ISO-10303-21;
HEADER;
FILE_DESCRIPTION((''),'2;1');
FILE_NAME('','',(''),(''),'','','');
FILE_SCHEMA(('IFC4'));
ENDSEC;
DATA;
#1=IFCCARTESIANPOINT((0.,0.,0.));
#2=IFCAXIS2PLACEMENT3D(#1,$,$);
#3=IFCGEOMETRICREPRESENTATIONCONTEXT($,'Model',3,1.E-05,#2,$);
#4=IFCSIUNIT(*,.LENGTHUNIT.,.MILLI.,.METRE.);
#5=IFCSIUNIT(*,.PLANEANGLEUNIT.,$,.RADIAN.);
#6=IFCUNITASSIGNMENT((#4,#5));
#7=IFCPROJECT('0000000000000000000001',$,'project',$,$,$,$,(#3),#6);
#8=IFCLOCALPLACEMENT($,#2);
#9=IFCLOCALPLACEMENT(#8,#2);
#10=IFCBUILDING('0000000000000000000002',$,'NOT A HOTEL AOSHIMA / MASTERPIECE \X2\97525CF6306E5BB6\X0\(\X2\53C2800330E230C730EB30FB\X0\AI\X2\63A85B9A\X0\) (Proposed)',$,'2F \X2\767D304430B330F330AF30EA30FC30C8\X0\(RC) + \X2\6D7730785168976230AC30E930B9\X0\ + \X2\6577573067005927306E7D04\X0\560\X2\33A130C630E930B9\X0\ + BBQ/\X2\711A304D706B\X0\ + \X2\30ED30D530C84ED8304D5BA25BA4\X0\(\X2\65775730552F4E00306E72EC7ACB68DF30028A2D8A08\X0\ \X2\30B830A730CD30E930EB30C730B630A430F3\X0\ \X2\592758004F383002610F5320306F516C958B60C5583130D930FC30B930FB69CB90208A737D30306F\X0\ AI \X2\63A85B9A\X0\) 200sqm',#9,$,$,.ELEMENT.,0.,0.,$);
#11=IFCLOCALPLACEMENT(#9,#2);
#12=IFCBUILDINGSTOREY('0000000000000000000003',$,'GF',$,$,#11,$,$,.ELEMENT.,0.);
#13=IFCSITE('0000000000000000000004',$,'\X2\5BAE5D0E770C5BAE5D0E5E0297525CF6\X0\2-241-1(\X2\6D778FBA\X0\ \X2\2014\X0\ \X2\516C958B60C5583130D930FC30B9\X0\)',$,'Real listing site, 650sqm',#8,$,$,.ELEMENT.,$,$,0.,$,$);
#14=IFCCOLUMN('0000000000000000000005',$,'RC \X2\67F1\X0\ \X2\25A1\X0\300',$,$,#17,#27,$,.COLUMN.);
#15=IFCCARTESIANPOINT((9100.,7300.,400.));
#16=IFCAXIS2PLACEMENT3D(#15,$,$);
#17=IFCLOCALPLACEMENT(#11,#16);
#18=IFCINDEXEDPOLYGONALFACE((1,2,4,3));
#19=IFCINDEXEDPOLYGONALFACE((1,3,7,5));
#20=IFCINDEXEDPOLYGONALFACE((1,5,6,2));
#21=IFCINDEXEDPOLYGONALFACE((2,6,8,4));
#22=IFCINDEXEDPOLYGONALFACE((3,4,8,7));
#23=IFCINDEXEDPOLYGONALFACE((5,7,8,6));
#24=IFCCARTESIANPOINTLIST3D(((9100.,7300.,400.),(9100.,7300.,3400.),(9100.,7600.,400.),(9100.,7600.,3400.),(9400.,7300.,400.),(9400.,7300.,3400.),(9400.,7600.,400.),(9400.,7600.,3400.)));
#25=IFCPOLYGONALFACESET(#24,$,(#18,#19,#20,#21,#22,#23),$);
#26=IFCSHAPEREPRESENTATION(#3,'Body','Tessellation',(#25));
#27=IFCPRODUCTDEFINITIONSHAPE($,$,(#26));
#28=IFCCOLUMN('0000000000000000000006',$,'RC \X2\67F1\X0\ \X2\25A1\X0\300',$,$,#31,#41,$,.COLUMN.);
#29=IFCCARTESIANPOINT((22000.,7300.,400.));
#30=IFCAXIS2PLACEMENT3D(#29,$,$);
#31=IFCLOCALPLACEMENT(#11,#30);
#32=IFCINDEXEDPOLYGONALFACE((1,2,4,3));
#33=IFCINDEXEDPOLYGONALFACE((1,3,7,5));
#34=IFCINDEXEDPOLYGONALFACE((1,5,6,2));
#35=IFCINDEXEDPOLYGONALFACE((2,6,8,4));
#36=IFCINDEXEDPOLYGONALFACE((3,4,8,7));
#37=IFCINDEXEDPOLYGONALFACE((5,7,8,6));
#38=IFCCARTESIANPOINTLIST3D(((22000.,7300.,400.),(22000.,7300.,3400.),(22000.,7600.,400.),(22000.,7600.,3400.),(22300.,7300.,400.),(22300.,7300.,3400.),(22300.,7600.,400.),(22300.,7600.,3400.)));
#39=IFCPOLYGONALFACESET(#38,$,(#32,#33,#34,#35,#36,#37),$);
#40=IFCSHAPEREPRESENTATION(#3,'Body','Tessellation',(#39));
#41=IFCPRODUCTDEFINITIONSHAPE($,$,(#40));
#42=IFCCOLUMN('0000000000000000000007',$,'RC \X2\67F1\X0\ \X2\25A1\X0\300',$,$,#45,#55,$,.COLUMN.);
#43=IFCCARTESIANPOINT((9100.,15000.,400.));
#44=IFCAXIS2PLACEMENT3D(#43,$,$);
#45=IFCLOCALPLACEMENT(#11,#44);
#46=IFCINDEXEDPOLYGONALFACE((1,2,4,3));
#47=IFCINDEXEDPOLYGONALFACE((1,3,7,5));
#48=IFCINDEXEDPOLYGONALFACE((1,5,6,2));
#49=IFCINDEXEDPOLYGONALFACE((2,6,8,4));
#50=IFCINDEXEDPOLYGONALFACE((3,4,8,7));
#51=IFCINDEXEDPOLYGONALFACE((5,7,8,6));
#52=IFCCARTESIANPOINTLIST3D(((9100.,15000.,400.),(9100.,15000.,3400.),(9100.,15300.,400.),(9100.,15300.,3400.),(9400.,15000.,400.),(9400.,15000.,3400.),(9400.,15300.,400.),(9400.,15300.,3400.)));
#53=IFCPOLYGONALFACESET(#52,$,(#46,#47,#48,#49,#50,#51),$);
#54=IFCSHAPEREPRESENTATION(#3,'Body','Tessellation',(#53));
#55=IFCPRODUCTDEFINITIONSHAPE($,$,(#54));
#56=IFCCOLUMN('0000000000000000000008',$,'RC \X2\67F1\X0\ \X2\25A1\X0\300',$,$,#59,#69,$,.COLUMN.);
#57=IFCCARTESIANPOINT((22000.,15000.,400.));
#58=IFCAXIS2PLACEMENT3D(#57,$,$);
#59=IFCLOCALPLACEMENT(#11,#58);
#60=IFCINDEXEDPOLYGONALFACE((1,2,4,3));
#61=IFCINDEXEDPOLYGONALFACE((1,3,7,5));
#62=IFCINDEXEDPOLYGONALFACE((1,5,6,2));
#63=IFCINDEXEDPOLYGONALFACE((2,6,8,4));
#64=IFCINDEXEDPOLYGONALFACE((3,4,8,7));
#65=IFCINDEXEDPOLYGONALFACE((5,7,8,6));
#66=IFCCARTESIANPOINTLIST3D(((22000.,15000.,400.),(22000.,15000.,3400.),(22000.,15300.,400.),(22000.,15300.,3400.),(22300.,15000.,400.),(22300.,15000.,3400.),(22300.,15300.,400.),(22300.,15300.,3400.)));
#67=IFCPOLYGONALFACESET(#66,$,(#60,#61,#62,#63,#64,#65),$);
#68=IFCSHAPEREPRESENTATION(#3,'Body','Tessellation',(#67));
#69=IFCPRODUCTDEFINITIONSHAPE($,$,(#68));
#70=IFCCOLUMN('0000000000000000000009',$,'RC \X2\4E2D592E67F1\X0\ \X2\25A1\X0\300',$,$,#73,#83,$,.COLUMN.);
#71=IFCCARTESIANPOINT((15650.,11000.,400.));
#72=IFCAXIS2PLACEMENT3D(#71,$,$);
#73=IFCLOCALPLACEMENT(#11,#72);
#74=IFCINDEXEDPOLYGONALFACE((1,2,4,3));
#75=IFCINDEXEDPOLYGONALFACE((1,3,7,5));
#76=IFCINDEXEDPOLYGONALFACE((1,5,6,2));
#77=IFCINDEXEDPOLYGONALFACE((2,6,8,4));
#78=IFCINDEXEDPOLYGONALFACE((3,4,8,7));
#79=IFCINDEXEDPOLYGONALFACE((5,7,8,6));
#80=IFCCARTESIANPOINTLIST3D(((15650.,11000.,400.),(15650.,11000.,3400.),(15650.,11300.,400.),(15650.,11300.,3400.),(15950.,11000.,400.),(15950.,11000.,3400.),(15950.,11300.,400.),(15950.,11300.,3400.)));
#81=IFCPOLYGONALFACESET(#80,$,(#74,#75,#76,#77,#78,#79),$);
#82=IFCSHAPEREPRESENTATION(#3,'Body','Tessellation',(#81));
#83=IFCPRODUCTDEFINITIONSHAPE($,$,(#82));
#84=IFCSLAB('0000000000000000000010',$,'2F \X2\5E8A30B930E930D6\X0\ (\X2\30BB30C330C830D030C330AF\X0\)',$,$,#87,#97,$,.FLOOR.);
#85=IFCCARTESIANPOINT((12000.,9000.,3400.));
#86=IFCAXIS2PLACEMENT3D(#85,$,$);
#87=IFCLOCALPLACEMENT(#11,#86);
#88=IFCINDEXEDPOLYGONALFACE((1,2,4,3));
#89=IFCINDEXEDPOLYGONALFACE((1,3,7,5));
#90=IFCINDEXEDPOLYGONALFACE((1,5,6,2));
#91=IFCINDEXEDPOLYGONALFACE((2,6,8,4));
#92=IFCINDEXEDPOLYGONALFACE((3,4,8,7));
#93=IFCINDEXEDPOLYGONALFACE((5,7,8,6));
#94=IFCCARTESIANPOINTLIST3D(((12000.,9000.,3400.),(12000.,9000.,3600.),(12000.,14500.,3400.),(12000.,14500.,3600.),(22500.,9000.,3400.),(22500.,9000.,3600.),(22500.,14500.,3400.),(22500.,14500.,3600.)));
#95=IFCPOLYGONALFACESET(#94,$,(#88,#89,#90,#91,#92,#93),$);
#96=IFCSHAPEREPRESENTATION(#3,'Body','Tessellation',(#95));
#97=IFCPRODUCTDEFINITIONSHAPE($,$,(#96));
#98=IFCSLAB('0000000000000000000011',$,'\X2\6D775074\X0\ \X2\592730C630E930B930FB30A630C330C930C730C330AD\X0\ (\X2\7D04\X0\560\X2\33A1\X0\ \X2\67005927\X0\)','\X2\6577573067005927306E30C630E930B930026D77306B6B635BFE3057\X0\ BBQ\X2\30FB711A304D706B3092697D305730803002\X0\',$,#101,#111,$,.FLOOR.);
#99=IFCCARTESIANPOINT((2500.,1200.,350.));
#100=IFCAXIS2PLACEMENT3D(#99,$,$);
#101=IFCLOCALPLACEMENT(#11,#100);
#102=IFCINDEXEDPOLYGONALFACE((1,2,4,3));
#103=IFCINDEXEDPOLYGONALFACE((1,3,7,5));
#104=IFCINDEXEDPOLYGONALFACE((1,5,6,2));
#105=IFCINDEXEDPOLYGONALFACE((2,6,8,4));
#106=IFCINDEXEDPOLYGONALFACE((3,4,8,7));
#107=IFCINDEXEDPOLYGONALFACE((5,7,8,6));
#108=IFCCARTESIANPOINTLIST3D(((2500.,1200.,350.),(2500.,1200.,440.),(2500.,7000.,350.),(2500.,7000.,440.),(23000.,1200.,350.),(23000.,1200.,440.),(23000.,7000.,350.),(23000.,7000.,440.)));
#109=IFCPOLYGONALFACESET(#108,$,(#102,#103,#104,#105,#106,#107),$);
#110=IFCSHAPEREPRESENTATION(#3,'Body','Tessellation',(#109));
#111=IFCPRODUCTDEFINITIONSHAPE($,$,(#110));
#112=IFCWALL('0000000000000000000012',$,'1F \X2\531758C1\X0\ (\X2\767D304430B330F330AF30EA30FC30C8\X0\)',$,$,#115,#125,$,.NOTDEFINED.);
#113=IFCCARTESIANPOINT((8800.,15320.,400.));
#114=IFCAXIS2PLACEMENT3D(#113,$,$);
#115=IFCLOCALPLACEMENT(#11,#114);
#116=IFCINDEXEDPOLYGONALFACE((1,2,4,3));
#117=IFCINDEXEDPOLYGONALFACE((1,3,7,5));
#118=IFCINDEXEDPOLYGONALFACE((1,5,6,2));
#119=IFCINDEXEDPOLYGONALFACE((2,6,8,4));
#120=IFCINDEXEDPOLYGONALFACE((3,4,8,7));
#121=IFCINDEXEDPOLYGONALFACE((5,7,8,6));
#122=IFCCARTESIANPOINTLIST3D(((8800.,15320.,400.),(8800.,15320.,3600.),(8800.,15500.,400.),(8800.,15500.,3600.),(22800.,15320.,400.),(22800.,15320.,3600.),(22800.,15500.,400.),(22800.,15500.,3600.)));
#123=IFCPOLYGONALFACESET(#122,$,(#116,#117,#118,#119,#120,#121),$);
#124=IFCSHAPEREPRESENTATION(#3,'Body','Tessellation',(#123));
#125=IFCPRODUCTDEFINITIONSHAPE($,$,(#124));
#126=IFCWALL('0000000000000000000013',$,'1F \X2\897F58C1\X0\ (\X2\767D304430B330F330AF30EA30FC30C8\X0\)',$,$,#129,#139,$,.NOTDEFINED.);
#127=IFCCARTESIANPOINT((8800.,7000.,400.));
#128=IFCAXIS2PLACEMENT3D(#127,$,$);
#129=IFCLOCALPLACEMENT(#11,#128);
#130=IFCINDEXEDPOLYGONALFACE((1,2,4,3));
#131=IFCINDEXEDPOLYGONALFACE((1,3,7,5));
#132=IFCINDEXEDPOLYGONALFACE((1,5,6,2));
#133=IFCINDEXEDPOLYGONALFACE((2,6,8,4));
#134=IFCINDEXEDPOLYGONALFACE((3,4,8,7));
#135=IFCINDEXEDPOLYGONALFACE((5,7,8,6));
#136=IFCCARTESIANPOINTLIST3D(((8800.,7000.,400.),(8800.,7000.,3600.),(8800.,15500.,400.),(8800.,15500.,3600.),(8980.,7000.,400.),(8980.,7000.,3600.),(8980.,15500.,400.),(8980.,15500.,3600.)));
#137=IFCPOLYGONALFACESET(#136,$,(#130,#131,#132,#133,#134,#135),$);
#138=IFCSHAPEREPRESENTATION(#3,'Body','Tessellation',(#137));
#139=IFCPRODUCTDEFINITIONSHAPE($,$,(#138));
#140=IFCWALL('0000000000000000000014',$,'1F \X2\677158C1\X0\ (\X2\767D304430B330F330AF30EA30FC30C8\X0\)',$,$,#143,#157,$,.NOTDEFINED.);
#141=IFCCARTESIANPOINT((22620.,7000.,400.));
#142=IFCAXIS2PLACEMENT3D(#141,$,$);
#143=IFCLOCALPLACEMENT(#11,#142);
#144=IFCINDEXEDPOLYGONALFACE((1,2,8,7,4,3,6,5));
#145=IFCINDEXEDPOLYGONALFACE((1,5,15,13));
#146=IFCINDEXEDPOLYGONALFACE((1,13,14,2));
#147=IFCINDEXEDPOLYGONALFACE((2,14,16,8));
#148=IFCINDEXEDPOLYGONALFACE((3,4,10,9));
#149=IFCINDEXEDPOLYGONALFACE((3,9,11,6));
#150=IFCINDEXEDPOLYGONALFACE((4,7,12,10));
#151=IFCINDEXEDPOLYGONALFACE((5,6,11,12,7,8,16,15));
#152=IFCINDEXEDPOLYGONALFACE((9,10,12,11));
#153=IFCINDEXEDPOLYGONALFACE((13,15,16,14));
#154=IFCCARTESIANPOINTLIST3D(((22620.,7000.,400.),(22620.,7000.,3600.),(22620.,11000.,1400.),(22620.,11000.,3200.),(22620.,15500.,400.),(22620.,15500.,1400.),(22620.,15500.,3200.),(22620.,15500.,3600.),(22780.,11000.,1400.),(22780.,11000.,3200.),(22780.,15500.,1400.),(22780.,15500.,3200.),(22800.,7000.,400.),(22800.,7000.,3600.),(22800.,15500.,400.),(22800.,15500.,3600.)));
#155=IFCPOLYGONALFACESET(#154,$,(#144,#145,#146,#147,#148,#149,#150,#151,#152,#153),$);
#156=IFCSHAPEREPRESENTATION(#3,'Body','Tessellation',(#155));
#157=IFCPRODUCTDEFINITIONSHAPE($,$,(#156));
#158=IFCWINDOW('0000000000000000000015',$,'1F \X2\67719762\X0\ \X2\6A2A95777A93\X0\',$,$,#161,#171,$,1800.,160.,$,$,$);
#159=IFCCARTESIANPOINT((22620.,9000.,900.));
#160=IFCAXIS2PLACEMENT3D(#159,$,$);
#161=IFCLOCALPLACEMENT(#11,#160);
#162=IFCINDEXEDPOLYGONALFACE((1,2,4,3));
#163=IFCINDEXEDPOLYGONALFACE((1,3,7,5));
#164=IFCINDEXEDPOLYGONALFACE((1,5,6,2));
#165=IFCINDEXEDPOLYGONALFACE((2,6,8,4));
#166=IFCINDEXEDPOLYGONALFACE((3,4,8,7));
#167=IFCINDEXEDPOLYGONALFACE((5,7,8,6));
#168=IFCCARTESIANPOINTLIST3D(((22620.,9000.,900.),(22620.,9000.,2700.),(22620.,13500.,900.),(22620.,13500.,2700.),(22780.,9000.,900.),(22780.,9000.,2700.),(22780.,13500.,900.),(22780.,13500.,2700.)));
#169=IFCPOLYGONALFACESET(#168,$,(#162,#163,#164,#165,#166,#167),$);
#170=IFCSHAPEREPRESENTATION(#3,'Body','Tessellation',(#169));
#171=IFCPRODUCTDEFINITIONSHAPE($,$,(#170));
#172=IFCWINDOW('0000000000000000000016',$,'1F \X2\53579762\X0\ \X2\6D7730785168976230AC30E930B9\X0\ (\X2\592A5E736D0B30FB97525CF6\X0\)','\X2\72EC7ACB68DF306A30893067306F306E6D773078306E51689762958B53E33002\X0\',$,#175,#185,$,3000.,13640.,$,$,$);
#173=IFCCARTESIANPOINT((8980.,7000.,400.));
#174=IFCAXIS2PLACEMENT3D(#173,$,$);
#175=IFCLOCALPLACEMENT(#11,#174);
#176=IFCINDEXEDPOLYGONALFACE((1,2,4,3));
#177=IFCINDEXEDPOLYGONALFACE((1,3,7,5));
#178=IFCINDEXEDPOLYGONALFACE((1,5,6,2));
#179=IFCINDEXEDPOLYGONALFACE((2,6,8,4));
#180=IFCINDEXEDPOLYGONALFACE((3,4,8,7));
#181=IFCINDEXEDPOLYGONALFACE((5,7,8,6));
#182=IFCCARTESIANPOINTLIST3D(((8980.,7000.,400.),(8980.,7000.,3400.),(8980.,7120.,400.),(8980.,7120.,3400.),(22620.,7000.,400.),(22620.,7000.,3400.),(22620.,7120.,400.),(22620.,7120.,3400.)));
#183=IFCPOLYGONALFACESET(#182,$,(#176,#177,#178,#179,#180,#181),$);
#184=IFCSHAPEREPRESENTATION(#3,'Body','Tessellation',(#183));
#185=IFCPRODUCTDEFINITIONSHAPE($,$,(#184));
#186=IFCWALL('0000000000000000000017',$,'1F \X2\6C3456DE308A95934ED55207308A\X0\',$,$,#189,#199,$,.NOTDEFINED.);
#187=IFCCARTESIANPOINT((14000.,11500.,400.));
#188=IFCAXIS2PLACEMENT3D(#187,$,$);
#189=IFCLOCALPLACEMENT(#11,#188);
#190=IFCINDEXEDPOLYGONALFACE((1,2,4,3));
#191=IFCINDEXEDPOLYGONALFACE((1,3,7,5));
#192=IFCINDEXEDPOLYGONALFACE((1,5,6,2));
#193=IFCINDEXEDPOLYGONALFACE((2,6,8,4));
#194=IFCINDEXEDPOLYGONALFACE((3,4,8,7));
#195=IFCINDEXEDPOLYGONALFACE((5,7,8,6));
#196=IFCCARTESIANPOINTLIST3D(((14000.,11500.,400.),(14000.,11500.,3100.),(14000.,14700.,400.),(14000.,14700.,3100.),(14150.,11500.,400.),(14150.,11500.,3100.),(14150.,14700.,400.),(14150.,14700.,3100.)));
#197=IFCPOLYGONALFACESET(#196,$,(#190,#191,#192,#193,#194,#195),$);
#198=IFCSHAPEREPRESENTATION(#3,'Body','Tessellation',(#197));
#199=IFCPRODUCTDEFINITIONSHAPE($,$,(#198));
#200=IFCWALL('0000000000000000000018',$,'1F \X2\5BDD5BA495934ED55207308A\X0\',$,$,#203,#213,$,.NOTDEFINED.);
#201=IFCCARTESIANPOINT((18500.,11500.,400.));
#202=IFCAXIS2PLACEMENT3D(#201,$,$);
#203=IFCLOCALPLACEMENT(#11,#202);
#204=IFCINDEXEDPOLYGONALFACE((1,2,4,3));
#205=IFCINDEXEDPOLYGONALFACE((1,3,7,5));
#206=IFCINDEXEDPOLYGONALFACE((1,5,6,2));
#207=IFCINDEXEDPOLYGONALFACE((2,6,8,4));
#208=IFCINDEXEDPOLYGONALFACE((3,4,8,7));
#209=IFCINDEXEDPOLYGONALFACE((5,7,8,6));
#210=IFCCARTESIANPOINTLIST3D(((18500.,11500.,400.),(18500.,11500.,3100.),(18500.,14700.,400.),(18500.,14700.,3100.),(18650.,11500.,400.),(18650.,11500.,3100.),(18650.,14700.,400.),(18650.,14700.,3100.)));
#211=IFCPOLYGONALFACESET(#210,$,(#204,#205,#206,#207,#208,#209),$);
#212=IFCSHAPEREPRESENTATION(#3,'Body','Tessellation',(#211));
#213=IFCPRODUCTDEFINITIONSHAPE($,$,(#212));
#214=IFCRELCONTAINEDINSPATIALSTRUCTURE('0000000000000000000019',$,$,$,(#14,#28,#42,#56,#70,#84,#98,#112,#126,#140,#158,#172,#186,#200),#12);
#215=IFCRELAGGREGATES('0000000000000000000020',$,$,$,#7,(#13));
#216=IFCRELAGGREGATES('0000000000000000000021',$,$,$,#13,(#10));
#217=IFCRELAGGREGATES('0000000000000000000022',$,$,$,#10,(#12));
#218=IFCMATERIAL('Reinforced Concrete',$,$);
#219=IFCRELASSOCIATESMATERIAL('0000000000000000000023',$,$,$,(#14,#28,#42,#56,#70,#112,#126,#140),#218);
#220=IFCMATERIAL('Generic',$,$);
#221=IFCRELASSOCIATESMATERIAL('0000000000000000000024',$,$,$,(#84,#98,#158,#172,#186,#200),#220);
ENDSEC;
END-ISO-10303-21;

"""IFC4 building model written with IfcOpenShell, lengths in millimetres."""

from ifc_helpers import new_model, si_unit, frame, frame_2d, origin, place, context, project, spatial, rectangle, extrude, material, element, fill, save


model = new_model("IFC4")

# Units and contexts
model_context = context("Model", 3, precision=1e-05, world=origin())
ifc_project = project(units=[si_unit("LENGTHUNIT", "METRE", prefix="MILLI"), si_unit("PLANEANGLEUNIT", "RADIAN")], contexts=[model_context])

# Site, building, storey
site_placement = place(None, origin())
site = spatial("IfcSite", under=ifc_project, at=site_placement, Name="宮崎県宮崎市青島2-241-1(海辺 — 公開情報ベース)", ObjectType="Real listing site, 650sqm", CompositionType="ELEMENT", RefElevation=0.0)
building_placement = place(site_placement, origin())
building = spatial("IfcBuilding", under=site, at=building_placement, Name="NOT A HOTEL AOSHIMA / MASTERPIECE 青島の家(参考モデル・AI推定) (Proposed)", ObjectType="2F 白いコンクリート(RC) + 海へ全面ガラス + 敷地最大の約560㎡テラス + BBQ/焚き火 + ロフト付き客室(敷地唯一の独立棟。設計 ジェネラルデザイン 大堀伸。意匠は公開情報ベース・構造詳細は AI 推定) 200sqm", CompositionType="ELEMENT", ElevationOfRefHeight=0.0, ElevationOfTerrain=0.0)
storey_placement = place(building_placement, origin())
storey = spatial("IfcBuildingStorey", under=building, at=storey_placement, Name="GF", CompositionType="ELEMENT", Elevation=0.0)

# Columns
ifc_material_1 = material(Name="Reinforced Concrete")
column_1_placement = place(storey_placement, frame((9100.0, 7300.0, 400.0)))
element("IfcColumn", 1, at=column_1_placement, inside=storey, material=ifc_material_1, Name="RC 柱 □300", PredefinedType="COLUMN", context=model_context, shape_type="SweptSolid", body=[
    extrude(rectangle(XDim=300.0, YDim=300.0, at=frame_2d((150.0, 150.0))), frame((9100.0, 7300.0, 400.0)), (0.0, 0.0, 1.0), 3000.0),
])
column_2_placement = place(storey_placement, frame((22000.0, 7300.0, 400.0)))
element("IfcColumn", 2, at=column_2_placement, inside=storey, material=ifc_material_1, Name="RC 柱 □300", PredefinedType="COLUMN", context=model_context, shape_type="SweptSolid", body=[
    extrude(rectangle(XDim=300.0, YDim=300.0, at=frame_2d((150.0, 150.0))), frame((22000.0, 7300.0, 400.0)), (0.0, 0.0, 1.0), 3000.0),
])
column_3_placement = place(storey_placement, frame((9100.0, 15000.0, 400.0)))
element("IfcColumn", 3, at=column_3_placement, inside=storey, material=ifc_material_1, Name="RC 柱 □300", PredefinedType="COLUMN", context=model_context, shape_type="SweptSolid", body=[
    extrude(rectangle(XDim=300.0, YDim=300.0, at=frame_2d((150.0, 150.0))), frame((9100.0, 15000.0, 400.0)), (0.0, 0.0, 1.0), 3000.0),
])
column_4_placement = place(storey_placement, frame((22000.0, 15000.0, 400.0)))
element("IfcColumn", 4, at=column_4_placement, inside=storey, material=ifc_material_1, Name="RC 柱 □300", PredefinedType="COLUMN", context=model_context, shape_type="SweptSolid", body=[
    extrude(rectangle(XDim=300.0, YDim=300.0, at=frame_2d((150.0, 150.0))), frame((22000.0, 15000.0, 400.0)), (0.0, 0.0, 1.0), 3000.0),
])
column_5_placement = place(storey_placement, frame((15650.0, 11000.0, 400.0)))
element("IfcColumn", 5, at=column_5_placement, inside=storey, material=ifc_material_1, Name="RC 中央柱 □300", PredefinedType="COLUMN", context=model_context, shape_type="SweptSolid", body=[
    extrude(rectangle(XDim=300.0, YDim=300.0, at=frame_2d((150.0, 150.0))), frame((15650.0, 11000.0, 400.0)), (0.0, 0.0, 1.0), 3000.0),
])

# Slabs
ifc_material_2 = material(Name="Generic")
slab_1_placement = place(storey_placement, frame((12000.0, 9000.0, 3400.0)))
element("IfcSlab", 6, at=slab_1_placement, inside=storey, material=ifc_material_2, Name="2F 床スラブ (セットバック)", PredefinedType="FLOOR", context=model_context, shape_type="SweptSolid", body=[
    extrude(rectangle(XDim=10500.0, YDim=5500.0, at=frame_2d((5250.0, 2750.0))), frame((12000.0, 9000.0, 3400.0)), (0.0, 0.0, 1.0), 200.0),
])
slab_2_placement = place(storey_placement, frame((2500.0, 1200.0, 350.0)))
element("IfcSlab", 7, at=slab_2_placement, inside=storey, material=ifc_material_2, Name="海側 大テラス・ウッドデッキ (約560㎡ 最大)", Description="敷地最大のテラス。海に正対し BBQ・焚き火を楽しむ。", PredefinedType="FLOOR", context=model_context, shape_type="SweptSolid", body=[
    extrude(rectangle(XDim=20500.0, YDim=5800.0, at=frame_2d((10250.0, 2900.0))), frame((2500.0, 1200.0, 350.0)), (0.0, 0.0, 1.0), 90.0),
])

# Walls
wall_1_placement = place(storey_placement, frame((8800.0, 15320.0, 400.0)))
element("IfcWall", 8, at=wall_1_placement, inside=storey, material=ifc_material_1, Name="1F 北壁 (白いコンクリート)", PredefinedType="NOTDEFINED", context=model_context, shape_type="SweptSolid", body=[
    extrude(rectangle(XDim=14000.0, YDim=180.0, at=frame_2d((7000.0, 90.0))), frame((8800.0, 15320.0, 400.0)), (0.0, 0.0, 1.0), 3200.0),
])
wall_2_placement = place(storey_placement, frame((8800.0, 7000.0, 400.0)))
element("IfcWall", 9, at=wall_2_placement, inside=storey, material=ifc_material_1, Name="1F 西壁 (白いコンクリート)", PredefinedType="NOTDEFINED", context=model_context, shape_type="SweptSolid", body=[
    extrude(rectangle(XDim=180.0, YDim=8500.0, at=frame_2d((90.0, 4250.0))), frame((8800.0, 7000.0, 400.0)), (0.0, 0.0, 1.0), 3200.0),
])

# Wall, opening, window
wall_3_placement = place(storey_placement, frame((22620.0, 7000.0, 400.0)))
wall_3 = element("IfcWall", 10, at=wall_3_placement, inside=storey, material=ifc_material_1, Name="1F 東壁 (白いコンクリート)", PredefinedType="NOTDEFINED", context=model_context, shape_type="SweptSolid", body=[
    extrude(rectangle(XDim=180.0, YDim=8500.0, at=frame_2d((90.0, 4250.0))), frame((22620.0, 7000.0, 400.0)), (0.0, 0.0, 1.0), 3200.0),
])
opening_placement = place(storey_placement, frame((22620.0, 9000.0, 900.0)))
opening = element("IfcOpeningElement", 11, at=opening_placement, cuts=wall_3, PredefinedType="NOTDEFINED", context=model_context, shape_type="SweptSolid", body=[
    extrude(rectangle(XDim=160.0, YDim=4500.0, at=frame_2d((80.0, 2250.0))), frame((22620.0, 9000.0, 900.0)), (0.0, 0.0, 1.0), 1800.0),
])
window_1_placement = place(storey_placement, frame((22620.0, 9000.0, 900.0)))
window_1 = element("IfcWindow", 12, at=window_1_placement, inside=storey, material=ifc_material_2, Name="1F 東面 横長窓", OverallHeight=1800.0, OverallWidth=160.0, context=model_context, shape_type="SweptSolid", body=[
    extrude(rectangle(XDim=160.0, YDim=4500.0, at=frame_2d((80.0, 2250.0))), frame((22620.0, 9000.0, 900.0)), (0.0, 0.0, 1.0), 1800.0),
])
fill(opening, window_1)

# Window
window_2_placement = place(storey_placement, frame((8980.0, 7000.0, 400.0)))
element("IfcWindow", 13, at=window_2_placement, inside=storey, material=ifc_material_2, Name="1F 南面 海へ全面ガラス (太平洋・青島)", Description="独立棟ならではの海への全面開口。", OverallHeight=3000.0, OverallWidth=13640.0, context=model_context, shape_type="SweptSolid", body=[
    extrude(rectangle(XDim=13640.0, YDim=120.0, at=frame_2d((6820.0, 60.0))), frame((8980.0, 7000.0, 400.0)), (0.0, 0.0, 1.0), 3000.0),
])

# Walls
wall_4_placement = place(storey_placement, frame((14000.0, 11500.0, 400.0)))
element("IfcWall", 14, at=wall_4_placement, inside=storey, material=ifc_material_2, Name="1F 水回り間仕切り", PredefinedType="NOTDEFINED", context=model_context, shape_type="SweptSolid", body=[
    extrude(rectangle(XDim=150.0, YDim=3200.0, at=frame_2d((75.0, 1600.0))), frame((14000.0, 11500.0, 400.0)), (0.0, 0.0, 1.0), 2700.0),
])
wall_5_placement = place(storey_placement, frame((18500.0, 11500.0, 400.0)))
element("IfcWall", 15, at=wall_5_placement, inside=storey, material=ifc_material_2, Name="1F 寝室間仕切り", PredefinedType="NOTDEFINED", context=model_context, shape_type="SweptSolid", body=[
    extrude(rectangle(XDim=150.0, YDim=3200.0, at=frame_2d((75.0, 1600.0))), frame((18500.0, 11500.0, 400.0)), (0.0, 0.0, 1.0), 2700.0),
])

save(model, "model.ifc")
